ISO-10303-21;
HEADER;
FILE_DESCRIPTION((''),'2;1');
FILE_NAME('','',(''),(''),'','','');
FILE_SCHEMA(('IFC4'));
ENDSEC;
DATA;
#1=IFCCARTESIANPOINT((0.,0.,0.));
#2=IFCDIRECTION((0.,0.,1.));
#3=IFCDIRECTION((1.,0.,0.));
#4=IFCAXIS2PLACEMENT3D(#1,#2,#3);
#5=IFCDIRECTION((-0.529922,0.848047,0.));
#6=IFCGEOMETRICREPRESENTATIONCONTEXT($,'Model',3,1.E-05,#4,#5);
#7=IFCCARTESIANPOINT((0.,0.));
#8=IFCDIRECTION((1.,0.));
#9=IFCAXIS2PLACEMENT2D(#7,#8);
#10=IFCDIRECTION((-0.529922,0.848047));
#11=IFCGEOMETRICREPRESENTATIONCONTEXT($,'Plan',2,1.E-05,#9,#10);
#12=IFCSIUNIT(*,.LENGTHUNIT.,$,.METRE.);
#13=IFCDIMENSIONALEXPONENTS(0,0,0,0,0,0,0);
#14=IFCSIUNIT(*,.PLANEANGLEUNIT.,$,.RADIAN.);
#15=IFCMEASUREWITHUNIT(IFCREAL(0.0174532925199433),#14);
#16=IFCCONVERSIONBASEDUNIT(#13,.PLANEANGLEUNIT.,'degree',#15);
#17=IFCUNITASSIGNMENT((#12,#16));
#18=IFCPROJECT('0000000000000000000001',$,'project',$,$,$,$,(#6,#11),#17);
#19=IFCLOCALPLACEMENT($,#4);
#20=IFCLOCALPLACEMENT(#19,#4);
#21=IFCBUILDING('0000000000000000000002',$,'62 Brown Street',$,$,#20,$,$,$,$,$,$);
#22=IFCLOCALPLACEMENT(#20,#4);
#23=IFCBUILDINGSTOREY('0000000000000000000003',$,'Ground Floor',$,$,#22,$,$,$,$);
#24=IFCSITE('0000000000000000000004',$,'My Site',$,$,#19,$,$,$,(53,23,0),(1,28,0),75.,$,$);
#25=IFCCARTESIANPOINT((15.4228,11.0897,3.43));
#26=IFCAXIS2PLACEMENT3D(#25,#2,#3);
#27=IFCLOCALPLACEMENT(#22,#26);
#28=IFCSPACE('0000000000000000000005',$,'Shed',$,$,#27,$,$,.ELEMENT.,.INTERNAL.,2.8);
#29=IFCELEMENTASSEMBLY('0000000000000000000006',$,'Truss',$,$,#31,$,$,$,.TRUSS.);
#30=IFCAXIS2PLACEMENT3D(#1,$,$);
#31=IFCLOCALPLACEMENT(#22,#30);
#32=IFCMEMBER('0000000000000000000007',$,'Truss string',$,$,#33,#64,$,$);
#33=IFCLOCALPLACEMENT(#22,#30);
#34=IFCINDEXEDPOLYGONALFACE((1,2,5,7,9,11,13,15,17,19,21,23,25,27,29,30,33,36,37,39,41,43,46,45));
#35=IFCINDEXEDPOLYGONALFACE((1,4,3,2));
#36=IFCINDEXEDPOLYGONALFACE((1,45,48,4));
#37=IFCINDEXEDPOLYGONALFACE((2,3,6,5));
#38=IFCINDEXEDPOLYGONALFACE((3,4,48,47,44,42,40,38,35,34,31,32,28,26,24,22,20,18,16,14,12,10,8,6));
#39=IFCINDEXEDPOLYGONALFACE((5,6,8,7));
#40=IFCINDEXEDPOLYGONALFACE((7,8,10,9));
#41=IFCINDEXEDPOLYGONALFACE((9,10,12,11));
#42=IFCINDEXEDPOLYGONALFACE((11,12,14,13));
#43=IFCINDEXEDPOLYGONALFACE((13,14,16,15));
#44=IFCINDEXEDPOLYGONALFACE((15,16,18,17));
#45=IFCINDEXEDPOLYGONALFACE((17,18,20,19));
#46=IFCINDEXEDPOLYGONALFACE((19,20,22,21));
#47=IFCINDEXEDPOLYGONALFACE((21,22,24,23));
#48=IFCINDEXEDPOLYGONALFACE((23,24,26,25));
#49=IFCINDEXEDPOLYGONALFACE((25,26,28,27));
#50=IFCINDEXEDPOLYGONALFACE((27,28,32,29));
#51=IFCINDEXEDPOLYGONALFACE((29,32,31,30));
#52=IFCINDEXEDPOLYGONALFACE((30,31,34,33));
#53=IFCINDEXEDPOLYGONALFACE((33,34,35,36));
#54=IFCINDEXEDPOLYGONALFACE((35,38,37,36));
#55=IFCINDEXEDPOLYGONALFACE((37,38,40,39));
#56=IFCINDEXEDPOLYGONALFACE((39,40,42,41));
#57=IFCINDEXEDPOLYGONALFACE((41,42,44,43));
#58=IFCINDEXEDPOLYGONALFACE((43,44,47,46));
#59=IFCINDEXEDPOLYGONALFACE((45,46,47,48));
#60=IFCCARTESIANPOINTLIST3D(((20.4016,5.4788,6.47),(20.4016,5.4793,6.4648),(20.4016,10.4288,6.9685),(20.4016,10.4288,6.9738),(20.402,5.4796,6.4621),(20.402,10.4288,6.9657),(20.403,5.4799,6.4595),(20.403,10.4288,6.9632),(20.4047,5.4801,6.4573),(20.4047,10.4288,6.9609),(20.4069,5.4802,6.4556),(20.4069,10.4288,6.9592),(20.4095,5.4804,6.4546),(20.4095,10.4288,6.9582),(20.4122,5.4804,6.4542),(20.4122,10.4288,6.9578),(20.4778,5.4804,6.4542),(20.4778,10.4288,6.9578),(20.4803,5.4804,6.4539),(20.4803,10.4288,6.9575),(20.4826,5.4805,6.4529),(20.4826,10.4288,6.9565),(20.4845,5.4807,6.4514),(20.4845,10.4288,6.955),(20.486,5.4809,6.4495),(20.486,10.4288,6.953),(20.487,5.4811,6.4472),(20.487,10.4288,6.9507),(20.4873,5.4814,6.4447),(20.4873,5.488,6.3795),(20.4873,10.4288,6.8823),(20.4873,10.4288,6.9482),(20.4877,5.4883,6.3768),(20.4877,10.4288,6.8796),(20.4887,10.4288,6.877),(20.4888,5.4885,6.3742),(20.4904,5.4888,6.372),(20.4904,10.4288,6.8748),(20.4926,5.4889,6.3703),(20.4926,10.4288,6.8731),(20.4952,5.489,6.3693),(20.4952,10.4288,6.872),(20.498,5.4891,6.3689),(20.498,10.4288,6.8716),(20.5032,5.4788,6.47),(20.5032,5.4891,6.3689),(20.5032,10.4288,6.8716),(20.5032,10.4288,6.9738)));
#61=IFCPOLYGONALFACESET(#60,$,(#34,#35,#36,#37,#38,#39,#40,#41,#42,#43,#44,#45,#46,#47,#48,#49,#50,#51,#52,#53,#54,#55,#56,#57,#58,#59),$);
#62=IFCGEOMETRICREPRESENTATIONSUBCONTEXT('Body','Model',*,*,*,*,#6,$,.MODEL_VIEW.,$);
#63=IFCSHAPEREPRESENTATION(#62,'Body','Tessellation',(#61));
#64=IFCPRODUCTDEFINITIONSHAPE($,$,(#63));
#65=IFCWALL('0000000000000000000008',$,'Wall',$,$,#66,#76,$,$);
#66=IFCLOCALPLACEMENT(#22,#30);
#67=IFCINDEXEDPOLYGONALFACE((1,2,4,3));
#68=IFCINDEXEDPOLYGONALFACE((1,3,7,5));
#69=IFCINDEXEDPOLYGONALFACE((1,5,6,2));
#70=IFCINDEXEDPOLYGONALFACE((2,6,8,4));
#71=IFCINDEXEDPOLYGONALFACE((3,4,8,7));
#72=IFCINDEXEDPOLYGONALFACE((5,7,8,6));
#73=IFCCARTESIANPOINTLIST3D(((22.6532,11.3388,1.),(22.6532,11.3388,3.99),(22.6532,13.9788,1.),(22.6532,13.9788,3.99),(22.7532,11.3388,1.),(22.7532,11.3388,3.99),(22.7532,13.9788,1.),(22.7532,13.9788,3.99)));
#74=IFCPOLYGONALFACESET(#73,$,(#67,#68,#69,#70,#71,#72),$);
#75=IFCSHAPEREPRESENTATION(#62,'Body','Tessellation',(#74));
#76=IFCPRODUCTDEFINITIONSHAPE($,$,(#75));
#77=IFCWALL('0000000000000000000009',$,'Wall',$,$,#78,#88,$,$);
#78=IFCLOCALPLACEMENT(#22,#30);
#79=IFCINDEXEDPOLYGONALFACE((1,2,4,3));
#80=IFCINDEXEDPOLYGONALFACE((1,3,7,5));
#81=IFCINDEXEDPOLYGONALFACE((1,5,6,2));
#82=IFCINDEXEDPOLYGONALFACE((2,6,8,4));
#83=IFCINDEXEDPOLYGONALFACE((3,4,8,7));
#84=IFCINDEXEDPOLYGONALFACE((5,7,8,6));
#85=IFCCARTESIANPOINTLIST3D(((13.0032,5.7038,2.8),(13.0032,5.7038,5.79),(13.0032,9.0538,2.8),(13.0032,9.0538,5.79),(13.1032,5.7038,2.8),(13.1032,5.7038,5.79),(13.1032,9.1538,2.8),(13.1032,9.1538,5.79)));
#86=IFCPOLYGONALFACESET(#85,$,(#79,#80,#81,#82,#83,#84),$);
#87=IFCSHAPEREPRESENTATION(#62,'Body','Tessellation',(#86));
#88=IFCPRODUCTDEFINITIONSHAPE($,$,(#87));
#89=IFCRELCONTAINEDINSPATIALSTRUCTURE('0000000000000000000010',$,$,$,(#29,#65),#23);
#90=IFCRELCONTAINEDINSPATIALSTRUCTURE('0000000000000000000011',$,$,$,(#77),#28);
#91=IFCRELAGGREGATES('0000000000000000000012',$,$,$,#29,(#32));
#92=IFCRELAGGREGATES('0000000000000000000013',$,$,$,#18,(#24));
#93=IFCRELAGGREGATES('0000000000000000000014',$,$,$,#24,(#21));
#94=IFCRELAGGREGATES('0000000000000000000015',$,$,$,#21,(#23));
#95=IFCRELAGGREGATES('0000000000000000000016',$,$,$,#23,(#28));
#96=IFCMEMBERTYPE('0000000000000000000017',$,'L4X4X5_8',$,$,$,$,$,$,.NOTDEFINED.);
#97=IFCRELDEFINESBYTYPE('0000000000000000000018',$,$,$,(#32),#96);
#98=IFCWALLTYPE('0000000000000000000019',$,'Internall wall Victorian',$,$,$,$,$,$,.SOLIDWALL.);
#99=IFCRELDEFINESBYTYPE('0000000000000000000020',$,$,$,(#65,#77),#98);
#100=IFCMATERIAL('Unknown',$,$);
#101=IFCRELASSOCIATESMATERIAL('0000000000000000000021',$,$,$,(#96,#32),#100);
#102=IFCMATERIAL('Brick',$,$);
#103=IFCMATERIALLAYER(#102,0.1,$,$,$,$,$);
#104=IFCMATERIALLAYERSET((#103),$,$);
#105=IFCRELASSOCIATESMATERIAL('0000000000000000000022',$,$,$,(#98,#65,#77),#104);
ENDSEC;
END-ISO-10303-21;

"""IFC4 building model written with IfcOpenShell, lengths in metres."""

from ifc_helpers import new_model, entity, si_unit, converted_unit, direction, frame, origin_with_axes, origin_2d_with_axis, place, context, subcontext, project, spatial, indexed_curve, l_section, outline, extrude, clip, halfspace, material, layer, layer_set, layer_usage, material_profile, profile_set, profile_usage, type_object, element, aggregate, save


model = new_model("IFC4")

# Units and contexts
model_context = context("Model", 3, precision=1e-05, world=origin_with_axes(), true_north=direction((-0.529922, 0.848047, 0.0)))
plan_context = context("Plan", 2, precision=1e-05, world=origin_2d_with_axis(), true_north=direction((-0.529922, 0.848047)))
body_context_1 = subcontext(model_context, "Body", "Model", "MODEL_VIEW")
ifc_project = project(units=[si_unit("LENGTHUNIT", "METRE"), converted_unit("PLANEANGLEUNIT", "degree", entity("IfcReal", 0.0174532925199433), si_unit("PLANEANGLEUNIT", "RADIAN"), dimensions=[0, 0, 0, 0, 0, 0, 0])], contexts=[model_context, plan_context])

# Site, building, storey
site_placement = place(None, origin_with_axes())
site = spatial("IfcSite", under=ifc_project, at=site_placement, Name="My Site", RefLatitude=(53, 23, 0), RefLongitude=(1, 28, 0), RefElevation=75.0)
building_placement = place(site_placement, origin_with_axes())
building = spatial("IfcBuilding", under=site, at=building_placement, Name="62 Brown Street")
storey_placement = place(building_placement, origin_with_axes())
storey = spatial("IfcBuildingStorey", under=building, at=storey_placement, Name="Ground Floor")

# Element assembly
assembly_placement = place(storey_placement, frame((20.5032, 10.4288, 6.9738), z_axis=(0.0, 0.0, 1.0), x_axis=(1.0, 0.0, 0.0)))
assembly = element("IfcElementAssembly", 1, at=assembly_placement, inside=storey, Name="Truss", PredefinedType="TRUSS")
ifc_material_1 = material(Name="Unknown")

# Shared definitions
space_1_placement = place(storey_placement, frame((15.4228, 11.0897, 3.43), z_axis=(0.0, 0.0, 1.0), x_axis=(1.0, 0.0, 0.0)))
space_1 = spatial("IfcSpace", under=storey, at=space_1_placement, Name="Shed", CompositionType="ELEMENT", PredefinedType="INTERNAL", ElevationWithFlooring=2.8)

# Member
ifc_material_profile_1 = material_profile(ifc_material_1, l_section(Depth=0.1016, Width=0.1016, Thickness=0.0159, FilletRadius=0.0095, EdgeRadius=0.0106))
ifc_profile_set_1 = profile_set([ifc_material_profile_1])
member_type_1 = type_object("IfcMemberType", Name="L4X4X5_8", PredefinedType="NOTDEFINED", material=ifc_profile_set_1)
ifc_profile_usage_1 = profile_usage(ifc_profile_set_1, cardinal=5)
member_1_placement = place(assembly_placement, frame((-0.0508, 0.3519, -0.0152), z_axis=(0.000001, -0.994861, -0.101247), x_axis=(-1.0, -0.000001, 0.0)))
member_1 = element("IfcMember", 2, at=member_1_placement, type_object=member_type_1, material=ifc_profile_usage_1, Name="Truss string", context=body_context_1, shape_type="Clipping", body=[
    clip(extrude(l_section(Depth=0.1016, Width=0.1016, Thickness=0.0159, FilletRadius=0.0095, EdgeRadius=0.0106), origin_with_axes(), (0.0, 0.0, 1.0), 5.3242), halfspace(frame((16.4524, -0.0508, 0.3486), z_axis=(0.0, 0.101247, -0.994861), x_axis=(1.0, -0.000001, 0.0)), False)),
])
aggregate(assembly, [member_1])

# Walls
ifc_material_2 = material(Name="Brick")
ifc_layer_1 = layer(ifc_material_2, 0.1)
ifc_layer_set_1 = layer_set([ifc_layer_1])
ifc_layer_usage_1 = layer_usage(ifc_layer_set_1, "AXIS2", "POSITIVE", 0.0)
wall_type_1 = type_object("IfcWallType", Name="Internall wall Victorian", PredefinedType="SOLIDWALL", material=ifc_layer_set_1)
wall_1_placement = place(storey_placement, frame((22.7532, 11.3388, 1.0), z_axis=(0.0, 0.0, 1.0), x_axis=(0.0, 1.0, 0.0)))
element("IfcWall", 3, at=wall_1_placement, inside=storey, type_object=wall_type_1, material=ifc_layer_usage_1, Name="Wall", context=body_context_1, shape_type="SweptSolid", body=[
    extrude(outline(indexed_curve([(0.0, 0.0), (0.0, 0.1), (2.64, 0.1), (2.64, 0.0), (0.0, 0.0)], self_intersect=False)), origin_with_axes(), (0.0, 0.0, 1.0), 2.99),
])
ifc_layer_usage_2 = layer_usage(ifc_layer_set_1, "AXIS2", "POSITIVE", 0.0)
wall_2_placement = place(None, frame((13.1032, 5.7038, 2.8), z_axis=(0.0, 0.0, 1.0), x_axis=(0.0, 1.0, 0.0)))
element("IfcWall", 4, at=wall_2_placement, inside=space_1, type_object=wall_type_1, material=ifc_layer_usage_2, Name="Wall", context=body_context_1, shape_type="Clipping", body=[
    clip(extrude(outline(indexed_curve([(0.0, 0.0), (0.0, 0.1), (3.45, 0.1), (3.45, 0.0), (0.0, 0.0)], self_intersect=False)), origin_with_axes(), (0.0, 0.0, 1.0), 2.99), halfspace(frame((3.45, 0.0, -2.8), z_axis=(0.70711, 0.707104, 0.0), x_axis=(0.707104, -0.70711, 0.0)), False)),
])

save(model, "model.ifc")
